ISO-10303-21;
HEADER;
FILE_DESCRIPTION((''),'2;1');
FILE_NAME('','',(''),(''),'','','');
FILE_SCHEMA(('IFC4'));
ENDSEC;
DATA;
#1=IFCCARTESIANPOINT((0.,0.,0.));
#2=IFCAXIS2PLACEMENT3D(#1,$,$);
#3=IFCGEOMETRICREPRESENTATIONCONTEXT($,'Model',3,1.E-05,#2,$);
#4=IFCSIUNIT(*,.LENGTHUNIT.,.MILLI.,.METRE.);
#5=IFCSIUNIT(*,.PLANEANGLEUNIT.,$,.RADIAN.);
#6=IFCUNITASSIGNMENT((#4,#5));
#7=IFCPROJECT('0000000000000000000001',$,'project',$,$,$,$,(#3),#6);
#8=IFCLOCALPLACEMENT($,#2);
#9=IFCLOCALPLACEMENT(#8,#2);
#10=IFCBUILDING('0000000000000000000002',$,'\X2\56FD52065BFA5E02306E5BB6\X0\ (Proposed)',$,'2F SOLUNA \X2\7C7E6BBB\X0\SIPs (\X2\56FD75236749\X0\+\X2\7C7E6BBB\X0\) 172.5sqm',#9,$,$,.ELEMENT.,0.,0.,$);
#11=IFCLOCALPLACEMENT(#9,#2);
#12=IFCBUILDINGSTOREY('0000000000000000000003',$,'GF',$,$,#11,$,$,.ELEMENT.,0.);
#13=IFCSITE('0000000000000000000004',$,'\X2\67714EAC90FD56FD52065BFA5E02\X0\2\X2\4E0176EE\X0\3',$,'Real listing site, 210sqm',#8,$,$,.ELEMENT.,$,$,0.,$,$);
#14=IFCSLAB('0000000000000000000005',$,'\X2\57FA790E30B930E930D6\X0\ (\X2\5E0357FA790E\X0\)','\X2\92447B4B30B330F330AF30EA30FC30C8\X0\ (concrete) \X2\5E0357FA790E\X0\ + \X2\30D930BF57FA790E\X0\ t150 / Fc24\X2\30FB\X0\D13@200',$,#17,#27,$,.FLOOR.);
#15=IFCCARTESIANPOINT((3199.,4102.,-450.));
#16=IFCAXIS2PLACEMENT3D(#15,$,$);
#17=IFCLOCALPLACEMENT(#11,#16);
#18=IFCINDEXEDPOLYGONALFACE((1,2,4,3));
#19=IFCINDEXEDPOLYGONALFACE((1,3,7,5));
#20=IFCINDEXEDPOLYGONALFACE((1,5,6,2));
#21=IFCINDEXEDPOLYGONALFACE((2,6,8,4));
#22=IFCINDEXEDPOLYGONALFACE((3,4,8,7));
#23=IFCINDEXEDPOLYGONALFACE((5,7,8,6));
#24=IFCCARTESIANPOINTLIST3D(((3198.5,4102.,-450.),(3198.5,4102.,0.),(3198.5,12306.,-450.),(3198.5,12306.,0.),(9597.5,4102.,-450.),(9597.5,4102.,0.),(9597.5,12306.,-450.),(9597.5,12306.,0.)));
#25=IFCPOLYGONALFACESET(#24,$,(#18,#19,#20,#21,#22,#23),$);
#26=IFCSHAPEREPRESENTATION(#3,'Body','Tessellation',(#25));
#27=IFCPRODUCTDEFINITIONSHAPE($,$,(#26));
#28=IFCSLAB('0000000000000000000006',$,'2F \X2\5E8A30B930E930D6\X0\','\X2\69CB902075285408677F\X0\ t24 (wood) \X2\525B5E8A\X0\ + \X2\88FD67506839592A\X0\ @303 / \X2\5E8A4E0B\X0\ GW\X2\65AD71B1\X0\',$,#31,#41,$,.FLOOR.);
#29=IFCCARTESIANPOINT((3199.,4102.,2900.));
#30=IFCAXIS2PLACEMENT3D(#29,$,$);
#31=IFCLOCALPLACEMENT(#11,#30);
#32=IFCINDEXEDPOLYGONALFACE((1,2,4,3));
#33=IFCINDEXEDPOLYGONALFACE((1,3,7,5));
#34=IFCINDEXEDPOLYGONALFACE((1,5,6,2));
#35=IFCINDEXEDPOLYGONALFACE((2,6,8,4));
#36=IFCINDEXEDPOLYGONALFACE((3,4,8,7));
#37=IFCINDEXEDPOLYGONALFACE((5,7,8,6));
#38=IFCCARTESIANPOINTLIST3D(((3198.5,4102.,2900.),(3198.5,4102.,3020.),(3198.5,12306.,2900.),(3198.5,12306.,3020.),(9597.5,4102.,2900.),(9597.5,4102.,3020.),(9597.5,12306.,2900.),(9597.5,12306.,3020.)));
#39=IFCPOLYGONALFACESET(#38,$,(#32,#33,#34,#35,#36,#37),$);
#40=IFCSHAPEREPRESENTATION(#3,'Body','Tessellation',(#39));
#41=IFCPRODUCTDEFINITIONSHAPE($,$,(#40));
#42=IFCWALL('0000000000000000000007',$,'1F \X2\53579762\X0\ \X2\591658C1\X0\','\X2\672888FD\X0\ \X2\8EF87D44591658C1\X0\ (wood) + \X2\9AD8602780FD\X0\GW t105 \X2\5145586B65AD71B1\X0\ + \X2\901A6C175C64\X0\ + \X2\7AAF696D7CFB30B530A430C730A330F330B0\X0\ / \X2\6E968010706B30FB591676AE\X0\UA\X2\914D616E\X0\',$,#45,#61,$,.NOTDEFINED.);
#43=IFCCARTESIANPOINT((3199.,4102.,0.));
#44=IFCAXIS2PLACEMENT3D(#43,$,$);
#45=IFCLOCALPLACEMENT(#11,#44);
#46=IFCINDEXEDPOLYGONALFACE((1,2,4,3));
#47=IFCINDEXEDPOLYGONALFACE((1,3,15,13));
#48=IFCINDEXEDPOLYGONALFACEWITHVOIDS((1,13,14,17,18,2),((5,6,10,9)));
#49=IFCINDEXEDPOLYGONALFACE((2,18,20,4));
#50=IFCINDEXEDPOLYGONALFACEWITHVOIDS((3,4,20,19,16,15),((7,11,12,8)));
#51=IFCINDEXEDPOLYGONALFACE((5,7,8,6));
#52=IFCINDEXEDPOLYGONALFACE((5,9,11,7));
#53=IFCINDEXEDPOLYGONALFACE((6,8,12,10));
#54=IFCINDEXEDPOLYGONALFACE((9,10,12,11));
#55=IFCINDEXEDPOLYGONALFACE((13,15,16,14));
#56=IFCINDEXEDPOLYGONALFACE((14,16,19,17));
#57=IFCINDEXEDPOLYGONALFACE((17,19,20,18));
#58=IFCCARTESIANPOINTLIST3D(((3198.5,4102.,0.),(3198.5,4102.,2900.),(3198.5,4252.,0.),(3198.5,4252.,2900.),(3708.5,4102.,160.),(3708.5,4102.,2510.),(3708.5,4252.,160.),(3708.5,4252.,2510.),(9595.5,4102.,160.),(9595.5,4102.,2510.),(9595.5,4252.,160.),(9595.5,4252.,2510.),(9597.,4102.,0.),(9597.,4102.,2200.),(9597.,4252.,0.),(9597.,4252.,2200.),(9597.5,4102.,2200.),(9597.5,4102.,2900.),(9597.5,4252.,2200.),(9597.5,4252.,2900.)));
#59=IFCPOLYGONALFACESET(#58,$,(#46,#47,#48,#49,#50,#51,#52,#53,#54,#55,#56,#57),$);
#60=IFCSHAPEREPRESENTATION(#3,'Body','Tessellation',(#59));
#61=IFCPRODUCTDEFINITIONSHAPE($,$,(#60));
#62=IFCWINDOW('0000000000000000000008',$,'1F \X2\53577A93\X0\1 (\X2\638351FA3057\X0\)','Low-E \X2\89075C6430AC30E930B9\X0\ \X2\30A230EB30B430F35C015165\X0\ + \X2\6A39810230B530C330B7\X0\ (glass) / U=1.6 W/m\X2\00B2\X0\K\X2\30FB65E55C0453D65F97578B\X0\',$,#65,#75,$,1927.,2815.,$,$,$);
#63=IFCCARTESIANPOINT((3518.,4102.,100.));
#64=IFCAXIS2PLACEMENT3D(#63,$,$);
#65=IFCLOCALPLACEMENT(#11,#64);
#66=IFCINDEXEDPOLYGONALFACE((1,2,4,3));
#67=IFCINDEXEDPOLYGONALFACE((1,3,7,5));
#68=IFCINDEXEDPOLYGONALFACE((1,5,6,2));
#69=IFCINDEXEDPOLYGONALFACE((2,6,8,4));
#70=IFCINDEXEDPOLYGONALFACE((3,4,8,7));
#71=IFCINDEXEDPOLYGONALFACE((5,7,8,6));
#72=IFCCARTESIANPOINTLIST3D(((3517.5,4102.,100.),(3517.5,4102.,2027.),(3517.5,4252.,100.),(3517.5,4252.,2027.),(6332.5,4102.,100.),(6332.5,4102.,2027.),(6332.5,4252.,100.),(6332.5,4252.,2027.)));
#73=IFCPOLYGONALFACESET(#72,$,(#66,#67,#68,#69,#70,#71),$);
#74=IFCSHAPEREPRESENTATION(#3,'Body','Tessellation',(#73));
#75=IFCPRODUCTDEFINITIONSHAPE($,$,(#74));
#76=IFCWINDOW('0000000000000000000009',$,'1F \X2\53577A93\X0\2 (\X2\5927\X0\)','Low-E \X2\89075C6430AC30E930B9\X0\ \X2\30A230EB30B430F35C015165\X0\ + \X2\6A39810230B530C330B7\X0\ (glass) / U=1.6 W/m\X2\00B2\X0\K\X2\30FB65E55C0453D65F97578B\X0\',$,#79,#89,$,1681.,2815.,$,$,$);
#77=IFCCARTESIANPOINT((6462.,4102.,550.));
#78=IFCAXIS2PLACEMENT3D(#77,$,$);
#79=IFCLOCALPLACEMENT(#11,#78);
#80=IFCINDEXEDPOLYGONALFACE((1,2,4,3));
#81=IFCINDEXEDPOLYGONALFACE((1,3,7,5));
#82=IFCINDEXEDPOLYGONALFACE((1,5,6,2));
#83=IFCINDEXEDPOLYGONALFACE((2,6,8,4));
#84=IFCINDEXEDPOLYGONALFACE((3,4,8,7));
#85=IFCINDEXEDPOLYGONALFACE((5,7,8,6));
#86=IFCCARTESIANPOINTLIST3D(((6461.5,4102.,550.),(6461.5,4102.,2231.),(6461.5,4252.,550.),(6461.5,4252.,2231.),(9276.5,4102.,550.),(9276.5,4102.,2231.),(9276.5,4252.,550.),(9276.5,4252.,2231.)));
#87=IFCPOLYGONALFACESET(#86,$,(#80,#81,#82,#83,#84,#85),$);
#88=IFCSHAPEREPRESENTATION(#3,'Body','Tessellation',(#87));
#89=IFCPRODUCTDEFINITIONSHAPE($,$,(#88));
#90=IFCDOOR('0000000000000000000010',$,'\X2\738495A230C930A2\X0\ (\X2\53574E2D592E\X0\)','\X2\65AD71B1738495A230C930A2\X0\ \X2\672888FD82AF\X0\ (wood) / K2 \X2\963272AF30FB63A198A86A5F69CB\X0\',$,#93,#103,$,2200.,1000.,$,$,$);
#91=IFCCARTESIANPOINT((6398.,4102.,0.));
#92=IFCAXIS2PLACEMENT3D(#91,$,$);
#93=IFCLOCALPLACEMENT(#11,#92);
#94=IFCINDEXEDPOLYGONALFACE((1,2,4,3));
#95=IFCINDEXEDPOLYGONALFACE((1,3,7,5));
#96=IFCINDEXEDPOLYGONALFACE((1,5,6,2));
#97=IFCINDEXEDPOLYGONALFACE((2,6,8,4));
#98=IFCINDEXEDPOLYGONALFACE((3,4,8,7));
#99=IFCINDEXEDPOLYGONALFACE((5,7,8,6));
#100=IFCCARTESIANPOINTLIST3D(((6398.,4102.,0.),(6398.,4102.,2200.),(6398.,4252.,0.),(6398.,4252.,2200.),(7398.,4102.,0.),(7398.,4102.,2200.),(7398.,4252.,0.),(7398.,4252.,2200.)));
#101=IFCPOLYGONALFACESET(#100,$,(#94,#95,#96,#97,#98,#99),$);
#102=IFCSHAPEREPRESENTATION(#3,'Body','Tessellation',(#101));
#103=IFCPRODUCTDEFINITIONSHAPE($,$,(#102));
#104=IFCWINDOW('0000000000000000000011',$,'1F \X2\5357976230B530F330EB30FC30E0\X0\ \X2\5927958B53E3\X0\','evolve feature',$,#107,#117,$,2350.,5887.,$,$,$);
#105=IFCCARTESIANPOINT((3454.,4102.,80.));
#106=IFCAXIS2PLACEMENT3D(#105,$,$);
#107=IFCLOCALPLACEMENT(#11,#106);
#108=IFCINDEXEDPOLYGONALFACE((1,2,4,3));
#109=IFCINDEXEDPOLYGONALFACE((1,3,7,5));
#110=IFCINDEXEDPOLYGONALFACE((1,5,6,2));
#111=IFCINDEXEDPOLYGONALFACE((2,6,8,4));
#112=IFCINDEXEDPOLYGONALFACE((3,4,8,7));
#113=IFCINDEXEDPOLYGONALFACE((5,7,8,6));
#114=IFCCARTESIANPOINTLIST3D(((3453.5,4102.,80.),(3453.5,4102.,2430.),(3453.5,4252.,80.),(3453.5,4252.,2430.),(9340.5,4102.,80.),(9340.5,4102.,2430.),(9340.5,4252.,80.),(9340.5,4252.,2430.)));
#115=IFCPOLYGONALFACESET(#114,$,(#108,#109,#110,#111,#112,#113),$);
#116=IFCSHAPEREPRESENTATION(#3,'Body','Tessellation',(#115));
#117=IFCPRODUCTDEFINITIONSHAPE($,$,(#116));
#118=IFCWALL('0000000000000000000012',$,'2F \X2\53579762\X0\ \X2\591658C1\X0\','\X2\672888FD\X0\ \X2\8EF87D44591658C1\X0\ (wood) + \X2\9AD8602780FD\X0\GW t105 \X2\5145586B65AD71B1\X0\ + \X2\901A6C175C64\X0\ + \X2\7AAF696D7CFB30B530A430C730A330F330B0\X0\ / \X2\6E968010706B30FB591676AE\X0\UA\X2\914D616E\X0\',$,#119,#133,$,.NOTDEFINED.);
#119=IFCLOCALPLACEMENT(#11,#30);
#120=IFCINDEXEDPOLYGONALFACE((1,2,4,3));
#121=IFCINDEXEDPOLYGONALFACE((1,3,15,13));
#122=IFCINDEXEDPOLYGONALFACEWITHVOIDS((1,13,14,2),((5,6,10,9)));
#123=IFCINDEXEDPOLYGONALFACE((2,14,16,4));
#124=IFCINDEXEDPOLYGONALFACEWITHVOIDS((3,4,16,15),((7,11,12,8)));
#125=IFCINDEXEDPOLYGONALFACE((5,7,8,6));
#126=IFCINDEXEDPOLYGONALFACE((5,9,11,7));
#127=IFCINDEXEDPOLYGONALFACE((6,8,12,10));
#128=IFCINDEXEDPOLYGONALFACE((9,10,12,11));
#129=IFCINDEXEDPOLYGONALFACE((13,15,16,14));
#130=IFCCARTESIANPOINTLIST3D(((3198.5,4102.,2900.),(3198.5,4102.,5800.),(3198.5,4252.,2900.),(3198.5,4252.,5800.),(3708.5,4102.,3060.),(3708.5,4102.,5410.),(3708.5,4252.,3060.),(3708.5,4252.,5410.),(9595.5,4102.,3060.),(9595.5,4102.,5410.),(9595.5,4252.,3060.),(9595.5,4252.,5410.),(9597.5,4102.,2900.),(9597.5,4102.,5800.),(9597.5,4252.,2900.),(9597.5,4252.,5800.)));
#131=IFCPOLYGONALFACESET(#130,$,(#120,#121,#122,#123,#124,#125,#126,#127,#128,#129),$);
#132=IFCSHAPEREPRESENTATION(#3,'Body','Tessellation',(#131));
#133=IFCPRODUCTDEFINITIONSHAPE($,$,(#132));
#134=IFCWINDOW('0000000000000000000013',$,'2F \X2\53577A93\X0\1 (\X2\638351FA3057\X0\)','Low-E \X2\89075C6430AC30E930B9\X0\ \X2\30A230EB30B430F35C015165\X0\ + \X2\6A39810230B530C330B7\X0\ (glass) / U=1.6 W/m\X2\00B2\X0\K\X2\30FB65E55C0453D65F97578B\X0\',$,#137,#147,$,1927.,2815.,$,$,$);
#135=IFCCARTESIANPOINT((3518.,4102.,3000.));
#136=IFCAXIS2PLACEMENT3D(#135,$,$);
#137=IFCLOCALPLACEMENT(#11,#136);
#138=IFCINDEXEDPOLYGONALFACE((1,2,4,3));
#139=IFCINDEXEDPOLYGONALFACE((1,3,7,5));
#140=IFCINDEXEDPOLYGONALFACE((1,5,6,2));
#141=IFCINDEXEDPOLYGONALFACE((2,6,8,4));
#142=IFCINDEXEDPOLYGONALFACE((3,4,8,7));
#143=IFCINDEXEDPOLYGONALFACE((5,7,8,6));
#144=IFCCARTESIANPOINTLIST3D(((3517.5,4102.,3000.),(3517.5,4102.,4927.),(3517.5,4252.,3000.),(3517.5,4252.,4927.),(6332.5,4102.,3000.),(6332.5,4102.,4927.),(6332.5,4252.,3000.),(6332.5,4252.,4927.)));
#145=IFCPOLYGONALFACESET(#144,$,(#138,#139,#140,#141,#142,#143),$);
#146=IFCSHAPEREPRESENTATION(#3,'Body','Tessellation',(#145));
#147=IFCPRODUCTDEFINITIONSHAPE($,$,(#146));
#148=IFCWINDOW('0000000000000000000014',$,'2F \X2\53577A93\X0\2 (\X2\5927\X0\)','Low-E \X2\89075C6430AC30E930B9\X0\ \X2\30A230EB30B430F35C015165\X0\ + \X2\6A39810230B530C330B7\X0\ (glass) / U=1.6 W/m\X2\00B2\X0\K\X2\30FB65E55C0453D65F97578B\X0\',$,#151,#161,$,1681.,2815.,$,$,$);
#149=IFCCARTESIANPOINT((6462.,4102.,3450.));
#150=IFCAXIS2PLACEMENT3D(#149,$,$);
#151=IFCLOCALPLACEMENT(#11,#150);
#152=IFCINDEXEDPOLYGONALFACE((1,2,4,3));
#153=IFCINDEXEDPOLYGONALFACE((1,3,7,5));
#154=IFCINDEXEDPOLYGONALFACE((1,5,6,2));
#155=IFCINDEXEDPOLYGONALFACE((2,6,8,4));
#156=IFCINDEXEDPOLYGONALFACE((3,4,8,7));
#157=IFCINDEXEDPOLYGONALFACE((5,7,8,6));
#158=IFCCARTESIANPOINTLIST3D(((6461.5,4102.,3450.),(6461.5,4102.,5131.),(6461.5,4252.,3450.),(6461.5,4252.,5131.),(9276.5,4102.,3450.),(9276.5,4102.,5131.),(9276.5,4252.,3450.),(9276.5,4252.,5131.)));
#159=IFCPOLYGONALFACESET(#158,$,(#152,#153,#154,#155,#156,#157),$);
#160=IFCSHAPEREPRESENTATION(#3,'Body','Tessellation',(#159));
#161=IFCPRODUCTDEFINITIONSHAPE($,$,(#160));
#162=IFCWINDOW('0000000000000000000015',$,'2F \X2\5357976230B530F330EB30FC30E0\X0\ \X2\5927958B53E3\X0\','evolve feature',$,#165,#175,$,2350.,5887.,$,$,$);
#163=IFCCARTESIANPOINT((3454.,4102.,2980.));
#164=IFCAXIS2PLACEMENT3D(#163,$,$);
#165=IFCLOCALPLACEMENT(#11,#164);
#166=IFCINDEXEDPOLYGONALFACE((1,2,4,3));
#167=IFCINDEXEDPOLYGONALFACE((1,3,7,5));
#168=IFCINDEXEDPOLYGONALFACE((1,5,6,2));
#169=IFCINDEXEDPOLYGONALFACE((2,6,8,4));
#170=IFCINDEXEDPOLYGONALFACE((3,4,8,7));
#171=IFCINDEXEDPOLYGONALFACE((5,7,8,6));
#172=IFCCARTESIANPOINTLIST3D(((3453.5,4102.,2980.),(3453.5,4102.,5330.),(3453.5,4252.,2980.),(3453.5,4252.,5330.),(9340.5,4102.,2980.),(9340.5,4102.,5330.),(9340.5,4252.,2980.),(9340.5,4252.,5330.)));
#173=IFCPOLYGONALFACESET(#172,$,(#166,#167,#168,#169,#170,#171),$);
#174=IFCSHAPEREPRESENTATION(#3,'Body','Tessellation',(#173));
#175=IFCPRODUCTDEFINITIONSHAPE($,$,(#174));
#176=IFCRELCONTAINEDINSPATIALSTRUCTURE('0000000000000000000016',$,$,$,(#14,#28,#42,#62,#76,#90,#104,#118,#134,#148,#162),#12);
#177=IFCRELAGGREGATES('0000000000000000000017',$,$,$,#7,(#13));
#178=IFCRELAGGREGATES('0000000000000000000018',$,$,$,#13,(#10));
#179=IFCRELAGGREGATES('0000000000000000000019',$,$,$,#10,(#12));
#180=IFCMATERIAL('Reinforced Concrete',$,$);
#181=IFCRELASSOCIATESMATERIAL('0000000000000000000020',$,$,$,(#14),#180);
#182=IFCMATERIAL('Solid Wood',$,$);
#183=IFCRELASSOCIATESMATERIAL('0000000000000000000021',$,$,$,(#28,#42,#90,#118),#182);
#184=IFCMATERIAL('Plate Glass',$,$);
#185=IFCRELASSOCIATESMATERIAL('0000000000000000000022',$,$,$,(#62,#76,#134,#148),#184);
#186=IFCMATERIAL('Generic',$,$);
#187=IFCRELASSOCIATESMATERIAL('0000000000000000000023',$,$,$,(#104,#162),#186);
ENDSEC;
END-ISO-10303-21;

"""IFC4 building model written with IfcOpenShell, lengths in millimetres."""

from ifc_helpers import new_model, si_unit, frame, frame_2d, origin, place, context, project, spatial, rectangle, extrude, material, element, fill, save


model = new_model("IFC4")

# Units and contexts
model_context = context("Model", 3, precision=1e-05, world=origin())
ifc_project = project(units=[si_unit("LENGTHUNIT", "METRE", prefix="MILLI"), si_unit("PLANEANGLEUNIT", "RADIAN")], contexts=[model_context])

# Site, building, storey
site_placement = place(None, origin())
site = spatial("IfcSite", under=ifc_project, at=site_placement, Name="東京都国分寺市2丁目3", ObjectType="Real listing site, 210sqm", CompositionType="ELEMENT", RefElevation=0.0)
building_placement = place(site_placement, origin())
building = spatial("IfcBuilding", under=site, at=building_placement, Name="国分寺市の家 (Proposed)", ObjectType="2F SOLUNA 籾殻SIPs (国産杉+籾殻) 172.5sqm", CompositionType="ELEMENT", ElevationOfRefHeight=0.0, ElevationOfTerrain=0.0)
storey_placement = place(building_placement, origin())
storey = spatial("IfcBuildingStorey", under=building, at=storey_placement, Name="GF", CompositionType="ELEMENT", Elevation=0.0)

# Slabs
ifc_material_1 = material(Name="Reinforced Concrete")
slab_1_placement = place(storey_placement, frame((3199.0, 4102.0, -450.0)))
element("IfcSlab", 1, at=slab_1_placement, inside=storey, material=ifc_material_1, Name="基礎スラブ (布基礎)", Description="鉄筋コンクリート (concrete) 布基礎 + ベタ基礎 t150 / Fc24・D13@200", PredefinedType="FLOOR", context=model_context, shape_type="SweptSolid", body=[
    extrude(rectangle(XDim=6399.0, YDim=8204.0, at=frame_2d((3199.0, 4102.0))), frame((3199.0, 4102.0, -450.0)), (0.0, 0.0, 1.0), 450.0),
])
ifc_material_2 = material(Name="Solid Wood")
slab_2_placement = place(storey_placement, frame((3199.0, 4102.0, 2900.0)))
element("IfcSlab", 2, at=slab_2_placement, inside=storey, material=ifc_material_2, Name="2F 床スラブ", Description="構造用合板 t24 (wood) 剛床 + 製材根太 @303 / 床下 GW断熱", PredefinedType="FLOOR", context=model_context, shape_type="SweptSolid", body=[
    extrude(rectangle(XDim=6399.0, YDim=8204.0, at=frame_2d((3199.0, 4102.0))), frame((3199.0, 4102.0, 2900.0)), (0.0, 0.0, 1.0), 120.0),
])
ifc_material_3 = material(Name="Generic")

# Wall, openings, windows, door
wall_1_placement = place(storey_placement, frame((3199.0, 4102.0, 0.0)))
wall_1 = element("IfcWall", 3, at=wall_1_placement, inside=storey, material=ifc_material_2, Name="1F 南面 外壁", Description="木製 軸組外壁 (wood) + 高性能GW t105 充填断熱 + 通気層 + 窯業系サイディング / 準耐火・外皮UA配慮", PredefinedType="NOTDEFINED", context=model_context, shape_type="SweptSolid", body=[
    extrude(rectangle(XDim=6399.0, YDim=150.0, at=frame_2d((3199.0, 75.0))), frame((3199.0, 4102.0, 0.0)), (0.0, 0.0, 1.0), 2900.0),
])
opening_1_placement = place(storey_placement, frame((3518.0, 4102.0, 100.0)))
opening_1 = element("IfcOpeningElement", 4, at=opening_1_placement, cuts=wall_1, PredefinedType="NOTDEFINED", context=model_context, shape_type="SweptSolid", body=[
    extrude(rectangle(XDim=2815.0, YDim=150.0, at=frame_2d((1407.0, 75.0))), frame((3518.0, 4102.0, 100.0)), (0.0, 0.0, 1.0), 1927.0),
])
opening_2_placement = place(storey_placement, frame((6462.0, 4102.0, 550.0)))
opening_2 = element("IfcOpeningElement", 5, at=opening_2_placement, cuts=wall_1, PredefinedType="NOTDEFINED", context=model_context, shape_type="SweptSolid", body=[
    extrude(rectangle(XDim=2815.0, YDim=150.0, at=frame_2d((1407.0, 75.0))), frame((6462.0, 4102.0, 550.0)), (0.0, 0.0, 1.0), 1681.0),
])
opening_3_placement = place(storey_placement, frame((6398.0, 4102.0, 0.0)))
opening_3 = element("IfcOpeningElement", 6, at=opening_3_placement, cuts=wall_1, PredefinedType="NOTDEFINED", context=model_context, shape_type="SweptSolid", body=[
    extrude(rectangle(XDim=1000.0, YDim=150.0, at=frame_2d((500.0, 75.0))), frame((6398.0, 4102.0, 0.0)), (0.0, 0.0, 1.0), 2200.0),
])
opening_4_placement = place(storey_placement, frame((3454.0, 4102.0, 80.0)))
opening_4 = element("IfcOpeningElement", 7, at=opening_4_placement, cuts=wall_1, PredefinedType="NOTDEFINED", context=model_context, shape_type="SweptSolid", body=[
    extrude(rectangle(XDim=5887.0, YDim=150.0, at=frame_2d((2943.0, 75.0))), frame((3454.0, 4102.0, 80.0)), (0.0, 0.0, 1.0), 2350.0),
])
ifc_material_4 = material(Name="Plate Glass")
window_1_placement = place(storey_placement, frame((3518.0, 4102.0, 100.0)))
window_1 = element("IfcWindow", 8, at=window_1_placement, inside=storey, material=ifc_material_4, Name="1F 南窓1 (掃出し)", Description="Low-E 複層ガラス アルゴン封入 + 樹脂サッシ (glass) / U=1.6 W/m²K・日射取得型", OverallHeight=1927.0, OverallWidth=2815.0, context=model_context, shape_type="SweptSolid", body=[
    extrude(rectangle(XDim=2815.0, YDim=150.0, at=frame_2d((1407.0, 75.0))), frame((3518.0, 4102.0, 100.0)), (0.0, 0.0, 1.0), 1927.0),
])
fill(opening_1, window_1)
window_2_placement = place(storey_placement, frame((6462.0, 4102.0, 550.0)))
window_2 = element("IfcWindow", 9, at=window_2_placement, inside=storey, material=ifc_material_4, Name="1F 南窓2 (大)", Description="Low-E 複層ガラス アルゴン封入 + 樹脂サッシ (glass) / U=1.6 W/m²K・日射取得型", OverallHeight=1681.0, OverallWidth=2815.0, context=model_context, shape_type="SweptSolid", body=[
    extrude(rectangle(XDim=2815.0, YDim=150.0, at=frame_2d((1407.0, 75.0))), frame((6462.0, 4102.0, 550.0)), (0.0, 0.0, 1.0), 1681.0),
])
fill(opening_2, window_2)
door_placement = place(storey_placement, frame((6398.0, 4102.0, 0.0)))
door = element("IfcDoor", 10, at=door_placement, inside=storey, material=ifc_material_2, Name="玄関ドア (南中央)", Description="断熱玄関ドア 木製芯 (wood) / K2 防犯・採風機構", OverallHeight=2200.0, OverallWidth=1000.0, context=model_context, shape_type="SweptSolid", body=[
    extrude(rectangle(XDim=1000.0, YDim=150.0, at=frame_2d((500.0, 75.0))), frame((6398.0, 4102.0, 0.0)), (0.0, 0.0, 1.0), 2200.0),
])
fill(opening_3, door)
window_3_placement = place(storey_placement, frame((3454.0, 4102.0, 80.0)))
window_3 = element("IfcWindow", 11, at=window_3_placement, inside=storey, material=ifc_material_3, Name="1F 南面サンルーム 大開口", Description="evolve feature", OverallHeight=2350.0, OverallWidth=5887.0, context=model_context, shape_type="SweptSolid", body=[
    extrude(rectangle(XDim=5887.0, YDim=150.0, at=frame_2d((2943.0, 75.0))), frame((3454.0, 4102.0, 80.0)), (0.0, 0.0, 1.0), 2350.0),
])
fill(opening_4, window_3)

# Wall, openings, windows
wall_2_placement = place(storey_placement, frame((3199.0, 4102.0, 2900.0)))
wall_2 = element("IfcWall", 12, at=wall_2_placement, inside=storey, material=ifc_material_2, Name="2F 南面 外壁", Description="木製 軸組外壁 (wood) + 高性能GW t105 充填断熱 + 通気層 + 窯業系サイディング / 準耐火・外皮UA配慮", PredefinedType="NOTDEFINED", context=model_context, shape_type="SweptSolid", body=[
    extrude(rectangle(XDim=6399.0, YDim=150.0, at=frame_2d((3199.0, 75.0))), frame((3199.0, 4102.0, 2900.0)), (0.0, 0.0, 1.0), 2900.0),
])
opening_5_placement = place(storey_placement, frame((3518.0, 4102.0, 3000.0)))
opening_5 = element("IfcOpeningElement", 13, at=opening_5_placement, cuts=wall_2, PredefinedType="NOTDEFINED", context=model_context, shape_type="SweptSolid", body=[
    extrude(rectangle(XDim=2815.0, YDim=150.0, at=frame_2d((1407.0, 75.0))), frame((3518.0, 4102.0, 3000.0)), (0.0, 0.0, 1.0), 1927.0),
])
opening_6_placement = place(storey_placement, frame((6462.0, 4102.0, 3450.0)))
opening_6 = element("IfcOpeningElement", 14, at=opening_6_placement, cuts=wall_2, PredefinedType="NOTDEFINED", context=model_context, shape_type="SweptSolid", body=[
    extrude(rectangle(XDim=2815.0, YDim=150.0, at=frame_2d((1407.0, 75.0))), frame((6462.0, 4102.0, 3450.0)), (0.0, 0.0, 1.0), 1681.0),
])
opening_7_placement = place(storey_placement, frame((3454.0, 4102.0, 2980.0)))
opening_7 = element("IfcOpeningElement", 15, at=opening_7_placement, cuts=wall_2, PredefinedType="NOTDEFINED", context=model_context, shape_type="SweptSolid", body=[
    extrude(rectangle(XDim=5887.0, YDim=150.0, at=frame_2d((2943.0, 75.0))), frame((3454.0, 4102.0, 2980.0)), (0.0, 0.0, 1.0), 2350.0),
])
window_4_placement = place(storey_placement, frame((3518.0, 4102.0, 3000.0)))
window_4 = element("IfcWindow", 16, at=window_4_placement, inside=storey, material=ifc_material_4, Name="2F 南窓1 (掃出し)", Description="Low-E 複層ガラス アルゴン封入 + 樹脂サッシ (glass) / U=1.6 W/m²K・日射取得型", OverallHeight=1927.0, OverallWidth=2815.0, context=model_context, shape_type="SweptSolid", body=[
    extrude(rectangle(XDim=2815.0, YDim=150.0, at=frame_2d((1407.0, 75.0))), frame((3518.0, 4102.0, 3000.0)), (0.0, 0.0, 1.0), 1927.0),
])
fill(opening_5, window_4)
window_5_placement = place(storey_placement, frame((6462.0, 4102.0, 3450.0)))
window_5 = element("IfcWindow", 17, at=window_5_placement, inside=storey, material=ifc_material_4, Name="2F 南窓2 (大)", Description="Low-E 複層ガラス アルゴン封入 + 樹脂サッシ (glass) / U=1.6 W/m²K・日射取得型", OverallHeight=1681.0, OverallWidth=2815.0, context=model_context, shape_type="SweptSolid", body=[
    extrude(rectangle(XDim=2815.0, YDim=150.0, at=frame_2d((1407.0, 75.0))), frame((6462.0, 4102.0, 3450.0)), (0.0, 0.0, 1.0), 1681.0),
])
fill(opening_6, window_5)
window_6_placement = place(storey_placement, frame((3454.0, 4102.0, 2980.0)))
window_6 = element("IfcWindow", 18, at=window_6_placement, inside=storey, material=ifc_material_3, Name="2F 南面サンルーム 大開口", Description="evolve feature", OverallHeight=2350.0, OverallWidth=5887.0, context=model_context, shape_type="SweptSolid", body=[
    extrude(rectangle(XDim=5887.0, YDim=150.0, at=frame_2d((2943.0, 75.0))), frame((3454.0, 4102.0, 2980.0)), (0.0, 0.0, 1.0), 2350.0),
])
fill(opening_7, window_6)

save(model, "model.ifc")
